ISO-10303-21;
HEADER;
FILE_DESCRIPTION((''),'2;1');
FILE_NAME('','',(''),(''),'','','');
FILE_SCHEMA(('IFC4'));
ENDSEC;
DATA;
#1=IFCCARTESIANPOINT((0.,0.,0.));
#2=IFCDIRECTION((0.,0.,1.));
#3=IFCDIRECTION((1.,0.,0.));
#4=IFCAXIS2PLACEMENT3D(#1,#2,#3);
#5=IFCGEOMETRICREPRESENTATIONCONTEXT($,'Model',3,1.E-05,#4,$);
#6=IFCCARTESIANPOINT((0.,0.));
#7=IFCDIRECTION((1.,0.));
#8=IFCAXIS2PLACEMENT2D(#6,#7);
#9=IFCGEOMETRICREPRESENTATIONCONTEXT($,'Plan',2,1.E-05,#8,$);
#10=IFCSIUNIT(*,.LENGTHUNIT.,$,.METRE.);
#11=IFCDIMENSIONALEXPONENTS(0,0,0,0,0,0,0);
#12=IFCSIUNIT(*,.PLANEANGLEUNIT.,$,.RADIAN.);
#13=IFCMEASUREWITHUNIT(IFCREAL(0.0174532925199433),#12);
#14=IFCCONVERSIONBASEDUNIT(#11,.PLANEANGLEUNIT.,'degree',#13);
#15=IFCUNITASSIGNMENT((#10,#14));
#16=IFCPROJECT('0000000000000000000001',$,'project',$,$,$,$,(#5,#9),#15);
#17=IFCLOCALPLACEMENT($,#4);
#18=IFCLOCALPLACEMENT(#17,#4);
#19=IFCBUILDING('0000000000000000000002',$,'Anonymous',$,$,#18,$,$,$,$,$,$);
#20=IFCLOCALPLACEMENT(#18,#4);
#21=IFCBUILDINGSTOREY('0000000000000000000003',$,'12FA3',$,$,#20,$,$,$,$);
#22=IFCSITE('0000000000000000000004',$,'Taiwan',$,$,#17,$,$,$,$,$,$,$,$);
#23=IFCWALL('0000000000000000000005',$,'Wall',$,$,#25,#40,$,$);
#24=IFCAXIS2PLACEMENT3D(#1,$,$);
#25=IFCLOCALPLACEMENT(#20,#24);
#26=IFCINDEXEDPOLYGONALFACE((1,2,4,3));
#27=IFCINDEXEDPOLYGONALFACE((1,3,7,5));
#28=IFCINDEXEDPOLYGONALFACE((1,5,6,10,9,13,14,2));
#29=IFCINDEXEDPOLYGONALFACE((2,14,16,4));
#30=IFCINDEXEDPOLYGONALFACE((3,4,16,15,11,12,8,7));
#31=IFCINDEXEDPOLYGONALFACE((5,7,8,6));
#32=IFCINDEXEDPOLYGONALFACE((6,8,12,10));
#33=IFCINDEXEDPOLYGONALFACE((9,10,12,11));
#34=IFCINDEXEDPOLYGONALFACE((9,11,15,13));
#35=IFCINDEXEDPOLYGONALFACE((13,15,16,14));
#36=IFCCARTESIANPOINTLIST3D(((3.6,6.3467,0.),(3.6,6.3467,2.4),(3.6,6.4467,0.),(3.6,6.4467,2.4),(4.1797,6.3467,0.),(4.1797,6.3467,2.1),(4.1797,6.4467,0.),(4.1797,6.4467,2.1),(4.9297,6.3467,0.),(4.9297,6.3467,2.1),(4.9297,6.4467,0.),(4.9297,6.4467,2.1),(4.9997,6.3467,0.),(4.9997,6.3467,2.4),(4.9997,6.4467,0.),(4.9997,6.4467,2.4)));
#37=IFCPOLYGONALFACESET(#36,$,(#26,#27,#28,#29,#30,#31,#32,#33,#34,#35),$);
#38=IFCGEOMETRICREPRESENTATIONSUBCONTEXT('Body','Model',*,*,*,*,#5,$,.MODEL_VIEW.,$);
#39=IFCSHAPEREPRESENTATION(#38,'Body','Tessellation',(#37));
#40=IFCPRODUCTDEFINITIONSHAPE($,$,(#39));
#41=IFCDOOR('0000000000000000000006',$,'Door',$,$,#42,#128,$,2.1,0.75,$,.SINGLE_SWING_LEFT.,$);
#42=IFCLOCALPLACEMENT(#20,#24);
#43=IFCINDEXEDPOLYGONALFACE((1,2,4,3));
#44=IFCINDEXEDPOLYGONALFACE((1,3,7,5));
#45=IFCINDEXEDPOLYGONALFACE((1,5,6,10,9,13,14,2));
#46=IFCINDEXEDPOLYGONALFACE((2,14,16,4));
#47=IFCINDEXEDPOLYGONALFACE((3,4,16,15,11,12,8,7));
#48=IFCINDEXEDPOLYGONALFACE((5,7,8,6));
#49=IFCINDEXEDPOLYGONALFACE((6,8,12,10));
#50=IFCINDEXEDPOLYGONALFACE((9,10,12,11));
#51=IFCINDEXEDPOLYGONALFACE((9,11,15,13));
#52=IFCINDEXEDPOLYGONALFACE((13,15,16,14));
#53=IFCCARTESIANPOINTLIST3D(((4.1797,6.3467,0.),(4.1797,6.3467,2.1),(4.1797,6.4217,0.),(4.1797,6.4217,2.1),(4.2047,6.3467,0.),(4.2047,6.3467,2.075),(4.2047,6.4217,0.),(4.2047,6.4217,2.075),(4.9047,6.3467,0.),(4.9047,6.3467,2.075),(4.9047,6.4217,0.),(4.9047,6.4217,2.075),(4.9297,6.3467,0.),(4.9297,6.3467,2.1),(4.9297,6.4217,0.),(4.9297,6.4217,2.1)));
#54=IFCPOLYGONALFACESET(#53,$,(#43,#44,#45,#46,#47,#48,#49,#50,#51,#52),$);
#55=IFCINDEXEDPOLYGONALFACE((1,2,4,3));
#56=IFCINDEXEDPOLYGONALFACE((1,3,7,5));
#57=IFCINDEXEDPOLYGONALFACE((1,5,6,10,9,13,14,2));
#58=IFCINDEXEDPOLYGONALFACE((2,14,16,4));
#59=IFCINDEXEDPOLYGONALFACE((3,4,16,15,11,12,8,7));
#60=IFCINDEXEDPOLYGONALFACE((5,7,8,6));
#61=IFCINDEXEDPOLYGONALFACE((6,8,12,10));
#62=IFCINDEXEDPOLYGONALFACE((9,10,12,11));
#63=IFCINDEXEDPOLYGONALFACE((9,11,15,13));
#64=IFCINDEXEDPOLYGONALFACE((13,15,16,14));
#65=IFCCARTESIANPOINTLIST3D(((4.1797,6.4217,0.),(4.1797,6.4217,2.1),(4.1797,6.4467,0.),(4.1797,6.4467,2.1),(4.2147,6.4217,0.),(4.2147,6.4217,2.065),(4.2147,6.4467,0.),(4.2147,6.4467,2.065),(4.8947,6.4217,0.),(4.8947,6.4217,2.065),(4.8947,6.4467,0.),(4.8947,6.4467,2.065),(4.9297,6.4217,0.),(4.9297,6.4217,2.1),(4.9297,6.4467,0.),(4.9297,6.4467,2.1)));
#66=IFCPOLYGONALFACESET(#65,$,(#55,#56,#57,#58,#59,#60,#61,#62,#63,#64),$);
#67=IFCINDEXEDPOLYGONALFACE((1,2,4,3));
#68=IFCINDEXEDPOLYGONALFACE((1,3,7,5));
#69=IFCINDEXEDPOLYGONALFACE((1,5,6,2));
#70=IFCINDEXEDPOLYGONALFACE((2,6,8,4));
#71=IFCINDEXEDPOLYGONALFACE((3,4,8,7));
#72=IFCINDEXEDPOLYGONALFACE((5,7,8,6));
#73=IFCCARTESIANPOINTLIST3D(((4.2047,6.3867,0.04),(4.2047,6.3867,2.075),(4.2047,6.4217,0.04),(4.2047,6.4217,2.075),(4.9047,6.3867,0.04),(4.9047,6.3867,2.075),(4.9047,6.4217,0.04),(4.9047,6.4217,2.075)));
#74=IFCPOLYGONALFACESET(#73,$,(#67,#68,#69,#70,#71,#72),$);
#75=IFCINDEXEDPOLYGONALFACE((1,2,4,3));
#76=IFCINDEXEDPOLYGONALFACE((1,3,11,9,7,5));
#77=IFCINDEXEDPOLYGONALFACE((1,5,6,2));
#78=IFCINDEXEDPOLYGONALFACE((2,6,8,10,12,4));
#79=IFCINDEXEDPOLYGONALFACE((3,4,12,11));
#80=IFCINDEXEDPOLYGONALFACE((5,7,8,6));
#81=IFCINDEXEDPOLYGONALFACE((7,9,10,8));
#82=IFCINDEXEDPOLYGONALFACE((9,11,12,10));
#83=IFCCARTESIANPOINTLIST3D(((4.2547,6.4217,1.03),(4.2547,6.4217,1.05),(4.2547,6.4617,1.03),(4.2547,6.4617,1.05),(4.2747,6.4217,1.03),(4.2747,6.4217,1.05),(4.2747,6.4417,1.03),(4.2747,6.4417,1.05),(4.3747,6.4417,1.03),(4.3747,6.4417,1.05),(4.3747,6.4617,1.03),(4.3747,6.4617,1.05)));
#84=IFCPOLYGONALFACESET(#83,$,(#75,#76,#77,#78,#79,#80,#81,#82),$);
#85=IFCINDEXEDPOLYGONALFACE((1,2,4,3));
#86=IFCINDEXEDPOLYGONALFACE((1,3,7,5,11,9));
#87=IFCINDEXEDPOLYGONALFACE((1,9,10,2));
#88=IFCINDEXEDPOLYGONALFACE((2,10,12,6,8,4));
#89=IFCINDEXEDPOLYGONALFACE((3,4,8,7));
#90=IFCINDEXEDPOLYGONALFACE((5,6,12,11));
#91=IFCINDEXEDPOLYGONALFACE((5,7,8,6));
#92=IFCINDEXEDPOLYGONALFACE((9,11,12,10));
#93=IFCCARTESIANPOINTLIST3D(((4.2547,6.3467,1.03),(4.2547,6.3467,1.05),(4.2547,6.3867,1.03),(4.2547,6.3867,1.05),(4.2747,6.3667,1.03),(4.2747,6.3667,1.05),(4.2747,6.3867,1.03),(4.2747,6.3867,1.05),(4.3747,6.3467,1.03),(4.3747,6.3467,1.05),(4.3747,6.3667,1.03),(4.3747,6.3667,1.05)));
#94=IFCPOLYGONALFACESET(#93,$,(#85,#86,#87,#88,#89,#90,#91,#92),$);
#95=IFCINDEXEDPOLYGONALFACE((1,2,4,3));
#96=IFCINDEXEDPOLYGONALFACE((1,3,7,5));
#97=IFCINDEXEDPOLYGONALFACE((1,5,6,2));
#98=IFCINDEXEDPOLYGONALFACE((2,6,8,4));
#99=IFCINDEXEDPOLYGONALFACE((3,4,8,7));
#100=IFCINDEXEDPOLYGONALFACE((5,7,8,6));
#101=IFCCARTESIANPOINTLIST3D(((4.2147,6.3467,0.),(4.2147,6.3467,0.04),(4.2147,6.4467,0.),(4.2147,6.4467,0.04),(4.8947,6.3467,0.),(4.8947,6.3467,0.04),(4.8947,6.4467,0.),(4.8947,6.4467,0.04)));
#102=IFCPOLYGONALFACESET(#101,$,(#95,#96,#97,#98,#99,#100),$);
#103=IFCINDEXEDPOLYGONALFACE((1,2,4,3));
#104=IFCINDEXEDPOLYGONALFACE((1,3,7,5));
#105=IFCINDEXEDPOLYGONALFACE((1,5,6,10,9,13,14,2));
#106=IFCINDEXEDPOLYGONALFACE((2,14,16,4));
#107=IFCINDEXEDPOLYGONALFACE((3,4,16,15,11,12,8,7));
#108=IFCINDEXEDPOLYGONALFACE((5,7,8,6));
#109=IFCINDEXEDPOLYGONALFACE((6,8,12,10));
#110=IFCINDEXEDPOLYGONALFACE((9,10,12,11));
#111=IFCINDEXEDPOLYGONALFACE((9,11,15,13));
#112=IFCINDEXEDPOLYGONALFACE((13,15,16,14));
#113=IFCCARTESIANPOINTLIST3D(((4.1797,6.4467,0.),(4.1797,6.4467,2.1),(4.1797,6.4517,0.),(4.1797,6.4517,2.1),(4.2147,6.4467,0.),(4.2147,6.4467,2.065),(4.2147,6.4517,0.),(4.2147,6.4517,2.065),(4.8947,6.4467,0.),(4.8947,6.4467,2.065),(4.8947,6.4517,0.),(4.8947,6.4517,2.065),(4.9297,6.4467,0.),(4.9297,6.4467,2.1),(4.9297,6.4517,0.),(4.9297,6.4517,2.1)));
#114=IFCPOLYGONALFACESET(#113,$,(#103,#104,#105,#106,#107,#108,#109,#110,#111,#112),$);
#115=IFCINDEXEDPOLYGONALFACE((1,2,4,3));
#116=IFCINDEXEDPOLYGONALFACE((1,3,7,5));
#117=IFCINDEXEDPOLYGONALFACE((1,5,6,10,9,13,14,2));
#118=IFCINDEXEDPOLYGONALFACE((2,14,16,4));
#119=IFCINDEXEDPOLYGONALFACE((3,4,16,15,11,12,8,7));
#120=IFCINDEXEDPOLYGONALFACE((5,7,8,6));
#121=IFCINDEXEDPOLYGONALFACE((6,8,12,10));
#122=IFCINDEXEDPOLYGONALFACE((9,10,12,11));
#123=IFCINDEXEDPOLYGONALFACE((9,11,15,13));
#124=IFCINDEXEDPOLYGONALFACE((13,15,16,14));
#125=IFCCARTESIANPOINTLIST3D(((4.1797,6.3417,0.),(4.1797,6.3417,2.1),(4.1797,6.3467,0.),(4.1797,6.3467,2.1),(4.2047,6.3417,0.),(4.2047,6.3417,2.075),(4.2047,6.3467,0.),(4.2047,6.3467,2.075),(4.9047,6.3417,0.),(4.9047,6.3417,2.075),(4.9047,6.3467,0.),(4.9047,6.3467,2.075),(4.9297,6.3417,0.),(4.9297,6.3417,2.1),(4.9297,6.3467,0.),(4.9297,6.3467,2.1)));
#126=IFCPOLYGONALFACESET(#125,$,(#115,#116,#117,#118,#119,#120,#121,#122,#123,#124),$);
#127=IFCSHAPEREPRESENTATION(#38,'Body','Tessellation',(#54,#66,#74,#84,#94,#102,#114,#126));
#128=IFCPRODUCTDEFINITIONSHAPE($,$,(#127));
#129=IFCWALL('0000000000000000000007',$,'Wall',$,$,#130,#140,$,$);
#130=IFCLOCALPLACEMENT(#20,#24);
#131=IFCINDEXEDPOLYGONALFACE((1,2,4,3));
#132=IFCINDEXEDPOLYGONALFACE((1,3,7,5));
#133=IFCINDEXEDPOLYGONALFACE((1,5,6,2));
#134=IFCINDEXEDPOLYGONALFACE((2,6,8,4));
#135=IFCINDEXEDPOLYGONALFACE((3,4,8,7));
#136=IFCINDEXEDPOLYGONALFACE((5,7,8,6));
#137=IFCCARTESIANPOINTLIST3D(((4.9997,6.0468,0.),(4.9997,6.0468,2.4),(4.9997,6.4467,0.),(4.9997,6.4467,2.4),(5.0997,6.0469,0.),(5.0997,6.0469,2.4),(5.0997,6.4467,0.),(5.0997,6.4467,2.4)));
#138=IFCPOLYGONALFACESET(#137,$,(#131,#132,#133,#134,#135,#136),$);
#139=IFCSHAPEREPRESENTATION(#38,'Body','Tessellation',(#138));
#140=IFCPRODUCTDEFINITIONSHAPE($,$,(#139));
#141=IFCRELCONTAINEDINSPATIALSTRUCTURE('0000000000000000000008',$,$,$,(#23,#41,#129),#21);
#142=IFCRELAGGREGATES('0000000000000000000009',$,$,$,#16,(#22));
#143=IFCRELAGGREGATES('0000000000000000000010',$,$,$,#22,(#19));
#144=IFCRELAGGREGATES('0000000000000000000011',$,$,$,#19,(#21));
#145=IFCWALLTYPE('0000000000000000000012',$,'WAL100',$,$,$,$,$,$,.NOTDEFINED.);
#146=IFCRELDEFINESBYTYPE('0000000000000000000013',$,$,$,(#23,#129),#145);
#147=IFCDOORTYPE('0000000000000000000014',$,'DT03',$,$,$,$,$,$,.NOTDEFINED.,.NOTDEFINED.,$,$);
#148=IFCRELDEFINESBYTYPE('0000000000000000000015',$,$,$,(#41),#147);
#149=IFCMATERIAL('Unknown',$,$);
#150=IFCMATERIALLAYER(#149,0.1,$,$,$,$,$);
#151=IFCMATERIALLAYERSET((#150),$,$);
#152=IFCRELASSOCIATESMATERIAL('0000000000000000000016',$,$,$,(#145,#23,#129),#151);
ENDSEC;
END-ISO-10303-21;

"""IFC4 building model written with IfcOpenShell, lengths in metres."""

from ifc_helpers import new_model, entity, si_unit, converted_unit, frame, origin_with_axes, origin_2d_with_axis, place, context, subcontext, project, spatial, line, indexed_curve, outline, extrude, shape, source, transform, mapped, material, layer, layer_set, layer_usage, type_object, type_shapes, element, fill, save


model = new_model("IFC4")

# Units and contexts
model_context = context("Model", 3, precision=1e-05, world=origin_with_axes())
plan_context = context("Plan", 2, precision=1e-05, world=origin_2d_with_axis())
body_context_1 = subcontext(model_context, "Body", "Model", "MODEL_VIEW")
body_context_2 = subcontext(plan_context, "Body", "Plan", "PLAN_VIEW")
ifc_project = project(units=[si_unit("LENGTHUNIT", "METRE"), converted_unit("PLANEANGLEUNIT", "degree", entity("IfcReal", 0.0174532925199433), si_unit("PLANEANGLEUNIT", "RADIAN"), dimensions=[0, 0, 0, 0, 0, 0, 0])], contexts=[model_context, plan_context])

# Site, building, storey
site_placement = place(None, origin_with_axes())
site = spatial("IfcSite", under=ifc_project, at=site_placement, Name="Taiwan")
building_placement = place(site_placement, origin_with_axes())
building = spatial("IfcBuilding", under=site, at=building_placement, Name="Anonymous")
storey_placement = place(building_placement, origin_with_axes())
storey = spatial("IfcBuildingStorey", under=building, at=storey_placement, Name="12FA3")

# Shared definitions
ifc_material = material(Name="Unknown")

# Shared definitions
ifc_layer_1 = layer(ifc_material, 0.1)
ifc_layer_set_1 = layer_set([ifc_layer_1])
wall_type_1 = type_object("IfcWallType", Name="WAL100", PredefinedType="NOTDEFINED", material=ifc_layer_set_1)

# Wall, opening, door
ifc_layer_usage_1 = layer_usage(ifc_layer_set_1, "AXIS2", "POSITIVE", 0.0)
wall_1_placement = place(storey_placement, frame((4.9997, 6.4467, 0.0), z_axis=(0.0, 0.0, 1.0), x_axis=(-1.0, 0.0, 0.0)))
wall_1 = element("IfcWall", 1, at=wall_1_placement, inside=storey, type_object=wall_type_1, material=ifc_layer_usage_1, Name="Wall", context=body_context_1, shape_type="SweptSolid", body=[
    extrude(outline(indexed_curve([(0.0, 0.0), (0.0, 0.1), (1.3997, 0.1), (1.3997, 0.0)], segments=[line(1, 2, 3, 4, 1)])), origin_with_axes(), (0.0, 0.0, 1.0), 2.4),
])
shared_shape_1 = source(origin_with_axes(), body_context_1, "Body", "SweptSolid", [
    extrude(outline(indexed_curve([(0.0, 0.0), (0.75, 0.0), (0.75, 2.1), (0.0, 2.1)], segments=[line(1, 2, 3, 4, 1)])), frame((0.0, -0.6, 0.0), z_axis=(0.0, -1.0, 0.0), x_axis=(1.0, 0.0, 0.0)), (0.0, 0.0, -1.0), 1.2),
])
opening_1_placement = place(wall_1_placement, frame((0.07, 0.0, 0.0), z_axis=(0.0, 0.0, 1.0), x_axis=(1.0, 0.0, 0.0)))
opening_1 = element("IfcOpeningElement", 2, at=opening_1_placement, cuts=wall_1, PredefinedType="OPENING", context=body_context_1, shape_type="MappedRepresentation", body=[
    mapped(shared_shape_1, transform((0.0, 0.0, 0.0), x_axis=(1.0, 0.0, 0.0), y_axis=(0.0, 1.0, 0.0), z_axis=(0.0, 0.0, 1.0), scale=1.0)),
])
door_type_1 = type_object("IfcDoorType", Name="DT03", OperationType="NOTDEFINED", PredefinedType="NOTDEFINED")
shared_shape_2 = source(origin_with_axes(), body_context_1, "Body", "SweptSolid", [
    extrude(outline(indexed_curve([(0.0, 0.0), (0.0, 2.1), (0.75, 2.1), (0.75, 0.0), (0.725, 0.0), (0.725, 2.075), (0.025, 2.075), (0.025, 0.0)], segments=[line(1, 2, 3, 4, 5, 6, 7, 8, 1)])), frame((0.0, 0.025, 0.0), z_axis=(0.0, -1.0, 0.0), x_axis=(1.0, 0.0, 0.0)), (0.0, 0.0, -1.0), 0.075),
    extrude(outline(indexed_curve([(0.0, 0.0), (0.0, 2.1), (0.75, 2.1), (0.75, 0.0), (0.715, 0.0), (0.715, 2.065), (0.035, 2.065), (0.035, 0.0)], segments=[line(1, 2, 3, 4, 5, 6, 7, 8, 1)])), frame((0.0, 0.0, 0.0), z_axis=(0.0, -1.0, 0.0), x_axis=(1.0, 0.0, 0.0)), (0.0, 0.0, -1.0), 0.025),
    extrude(outline(indexed_curve([(0.0, 0.0), (0.7, 0.0), (0.7, 0.035), (0.0, 0.035)], segments=[line(1, 2, 3, 4, 1)])), frame((0.025, 0.025, 0.04), z_axis=(0.0, 0.0, 1.0), x_axis=(1.0, 0.0, 0.0)), (0.0, 0.0, 1.0), 2.035),
    extrude(outline(indexed_curve([(0.0, 0.0), (0.0, -0.04), (-0.12, -0.04), (-0.12, -0.02), (-0.02, -0.02), (-0.02, 0.0)], segments=[line(1, 2, 3, 4, 5, 6, 1)])), frame((0.675, 0.025, 1.03), z_axis=(0.0, 0.0, 1.0), x_axis=(1.0, 0.0, 0.0)), (0.0, 0.0, 1.0), 0.02),
    extrude(outline(indexed_curve([(0.0, 0.0), (0.0, 0.04), (-0.12, 0.04), (-0.12, 0.02), (-0.02, 0.02), (-0.02, 0.0)], segments=[line(1, 2, 3, 4, 5, 6, 1)])), frame((0.675, 0.06, 1.03), z_axis=(0.0, 0.0, 1.0), x_axis=(1.0, 0.0, 0.0)), (0.0, 0.0, 1.0), 0.02),
    extrude(outline(indexed_curve([(0.0, 0.0), (0.68, 0.0), (0.68, 0.1), (0.0, 0.1)], segments=[line(1, 2, 3, 4, 1)])), frame((0.035, 0.0, 0.0), z_axis=(0.0, 0.0, 1.0), x_axis=(1.0, 0.0, 0.0)), (0.0, 0.0, 1.0), 0.04),
    extrude(outline(indexed_curve([(0.0, 0.0), (0.0, 2.1), (0.75, 2.1), (0.75, 0.0), (0.715, 0.0), (0.715, 2.065), (0.035, 2.065), (0.035, 0.0)], segments=[line(1, 2, 3, 4, 5, 6, 7, 8, 1)])), frame((0.0, -0.005, 0.0), z_axis=(0.0, -1.0, 0.0), x_axis=(1.0, 0.0, 0.0)), (0.0, 0.0, -1.0), 0.005),
    extrude(outline(indexed_curve([(0.0, 0.0), (0.0, 2.1), (0.75, 2.1), (0.75, 0.0), (0.725, 0.0), (0.725, 2.075), (0.025, 2.075), (0.025, 0.0)], segments=[line(1, 2, 3, 4, 5, 6, 7, 8, 1)])), frame((0.0, 0.1, 0.0), z_axis=(0.0, -1.0, 0.0), x_axis=(1.0, 0.0, 0.0)), (0.0, 0.0, -1.0), 0.005),
])
shared_shape_3 = source(origin_with_axes(), body_context_2, "Body", "Curve2D", [
    entity("IfcIndexedPolyCurve", entity("IfcCartesianPointList2D", [[0.0, 0.0], [0.0, 0.1], [0.025, 0.1], [0.025, 0.025], [0.035, 0.025], [0.035, 0.0]]), [entity("IfcLineIndex", [1, 2, 3, 4, 5, 6, 1])]),
    entity("IfcIndexedPolyCurve", entity("IfcCartesianPointList2D", [[0.75, 0.0], [0.75, 0.1], [0.725, 0.1], [0.725, 0.025], [0.715, 0.025], [0.715, 0.0]]), [entity("IfcLineIndex", [1, 2, 3, 4, 5, 6, 1])]),
    entity("IfcTrimmedCurve", entity("IfcEllipse", entity("IfcAxis2Placement2D", entity("IfcCartesianPoint", [0.06, 0.1]), entity("IfcDirection", [1.0, 0.0])), 0.665, 0.7), [entity("IfcCartesianPoint", [0.725, 0.1])], [entity("IfcCartesianPoint", [0.06, 0.8])], True, "CARTESIAN"),
    entity("IfcIndexedPolyCurve", entity("IfcCartesianPointList2D", [[0.025, 0.1], [0.06, 0.1], [0.06, 0.8], [0.025, 0.8]]), [entity("IfcLineIndex", [1, 2, 3, 4, 1])]),
])
type_shapes(door_type_1, [shared_shape_2, shared_shape_3])
door_1_placement = place(opening_1_placement, frame((0.0, 0.0, 0.0), z_axis=(0.0, 0.0, 1.0), x_axis=(1.0, 0.0, 0.0)))
door_1 = element("IfcDoor", 3, at=door_1_placement, inside=storey, type_object=door_type_1, Name="Door", OperationType="SINGLE_SWING_LEFT", OverallHeight=2.1, OverallWidth=0.75, shapes=[
    shape(body_context_1, "Body", "MappedRepresentation", [mapped(shared_shape_2, transform((0.0, 0.0, 0.0), x_axis=(1.0, 0.0, 0.0), y_axis=(0.0, 1.0, 0.0), z_axis=(0.0, 0.0, 1.0), scale=1.0))]),
    shape(body_context_2, "Body", "MappedRepresentation", [mapped(shared_shape_3, transform((0.0, 0.0, 0.0), x_axis=(1.0, 0.0, 0.0), y_axis=(0.0, 1.0, 0.0), z_axis=(0.0, 0.0, 1.0), scale=1.0))]),
])
fill(opening_1, door_1)

# Wall
ifc_layer_usage_2 = layer_usage(ifc_layer_set_1, "AXIS2", "POSITIVE", 0.0)
wall_2_placement = place(storey_placement, frame((4.9997, 6.4467, 0.0), z_axis=(0.0, 0.0, 1.0), x_axis=(0.000135, -1.0, 0.0)))
element("IfcWall", 4, at=wall_2_placement, inside=storey, type_object=wall_type_1, material=ifc_layer_usage_2, Name="Wall", context=body_context_1, shape_type="SweptSolid", body=[
    extrude(outline(indexed_curve([(0.0, 0.0), (0.0, 0.1), (0.3998, 0.1), (0.3998, 0.0)], segments=[line(1, 2, 3, 4, 1)])), origin_with_axes(), (0.0, 0.0, 1.0), 2.4),
])

save(model, "model.ifc")
